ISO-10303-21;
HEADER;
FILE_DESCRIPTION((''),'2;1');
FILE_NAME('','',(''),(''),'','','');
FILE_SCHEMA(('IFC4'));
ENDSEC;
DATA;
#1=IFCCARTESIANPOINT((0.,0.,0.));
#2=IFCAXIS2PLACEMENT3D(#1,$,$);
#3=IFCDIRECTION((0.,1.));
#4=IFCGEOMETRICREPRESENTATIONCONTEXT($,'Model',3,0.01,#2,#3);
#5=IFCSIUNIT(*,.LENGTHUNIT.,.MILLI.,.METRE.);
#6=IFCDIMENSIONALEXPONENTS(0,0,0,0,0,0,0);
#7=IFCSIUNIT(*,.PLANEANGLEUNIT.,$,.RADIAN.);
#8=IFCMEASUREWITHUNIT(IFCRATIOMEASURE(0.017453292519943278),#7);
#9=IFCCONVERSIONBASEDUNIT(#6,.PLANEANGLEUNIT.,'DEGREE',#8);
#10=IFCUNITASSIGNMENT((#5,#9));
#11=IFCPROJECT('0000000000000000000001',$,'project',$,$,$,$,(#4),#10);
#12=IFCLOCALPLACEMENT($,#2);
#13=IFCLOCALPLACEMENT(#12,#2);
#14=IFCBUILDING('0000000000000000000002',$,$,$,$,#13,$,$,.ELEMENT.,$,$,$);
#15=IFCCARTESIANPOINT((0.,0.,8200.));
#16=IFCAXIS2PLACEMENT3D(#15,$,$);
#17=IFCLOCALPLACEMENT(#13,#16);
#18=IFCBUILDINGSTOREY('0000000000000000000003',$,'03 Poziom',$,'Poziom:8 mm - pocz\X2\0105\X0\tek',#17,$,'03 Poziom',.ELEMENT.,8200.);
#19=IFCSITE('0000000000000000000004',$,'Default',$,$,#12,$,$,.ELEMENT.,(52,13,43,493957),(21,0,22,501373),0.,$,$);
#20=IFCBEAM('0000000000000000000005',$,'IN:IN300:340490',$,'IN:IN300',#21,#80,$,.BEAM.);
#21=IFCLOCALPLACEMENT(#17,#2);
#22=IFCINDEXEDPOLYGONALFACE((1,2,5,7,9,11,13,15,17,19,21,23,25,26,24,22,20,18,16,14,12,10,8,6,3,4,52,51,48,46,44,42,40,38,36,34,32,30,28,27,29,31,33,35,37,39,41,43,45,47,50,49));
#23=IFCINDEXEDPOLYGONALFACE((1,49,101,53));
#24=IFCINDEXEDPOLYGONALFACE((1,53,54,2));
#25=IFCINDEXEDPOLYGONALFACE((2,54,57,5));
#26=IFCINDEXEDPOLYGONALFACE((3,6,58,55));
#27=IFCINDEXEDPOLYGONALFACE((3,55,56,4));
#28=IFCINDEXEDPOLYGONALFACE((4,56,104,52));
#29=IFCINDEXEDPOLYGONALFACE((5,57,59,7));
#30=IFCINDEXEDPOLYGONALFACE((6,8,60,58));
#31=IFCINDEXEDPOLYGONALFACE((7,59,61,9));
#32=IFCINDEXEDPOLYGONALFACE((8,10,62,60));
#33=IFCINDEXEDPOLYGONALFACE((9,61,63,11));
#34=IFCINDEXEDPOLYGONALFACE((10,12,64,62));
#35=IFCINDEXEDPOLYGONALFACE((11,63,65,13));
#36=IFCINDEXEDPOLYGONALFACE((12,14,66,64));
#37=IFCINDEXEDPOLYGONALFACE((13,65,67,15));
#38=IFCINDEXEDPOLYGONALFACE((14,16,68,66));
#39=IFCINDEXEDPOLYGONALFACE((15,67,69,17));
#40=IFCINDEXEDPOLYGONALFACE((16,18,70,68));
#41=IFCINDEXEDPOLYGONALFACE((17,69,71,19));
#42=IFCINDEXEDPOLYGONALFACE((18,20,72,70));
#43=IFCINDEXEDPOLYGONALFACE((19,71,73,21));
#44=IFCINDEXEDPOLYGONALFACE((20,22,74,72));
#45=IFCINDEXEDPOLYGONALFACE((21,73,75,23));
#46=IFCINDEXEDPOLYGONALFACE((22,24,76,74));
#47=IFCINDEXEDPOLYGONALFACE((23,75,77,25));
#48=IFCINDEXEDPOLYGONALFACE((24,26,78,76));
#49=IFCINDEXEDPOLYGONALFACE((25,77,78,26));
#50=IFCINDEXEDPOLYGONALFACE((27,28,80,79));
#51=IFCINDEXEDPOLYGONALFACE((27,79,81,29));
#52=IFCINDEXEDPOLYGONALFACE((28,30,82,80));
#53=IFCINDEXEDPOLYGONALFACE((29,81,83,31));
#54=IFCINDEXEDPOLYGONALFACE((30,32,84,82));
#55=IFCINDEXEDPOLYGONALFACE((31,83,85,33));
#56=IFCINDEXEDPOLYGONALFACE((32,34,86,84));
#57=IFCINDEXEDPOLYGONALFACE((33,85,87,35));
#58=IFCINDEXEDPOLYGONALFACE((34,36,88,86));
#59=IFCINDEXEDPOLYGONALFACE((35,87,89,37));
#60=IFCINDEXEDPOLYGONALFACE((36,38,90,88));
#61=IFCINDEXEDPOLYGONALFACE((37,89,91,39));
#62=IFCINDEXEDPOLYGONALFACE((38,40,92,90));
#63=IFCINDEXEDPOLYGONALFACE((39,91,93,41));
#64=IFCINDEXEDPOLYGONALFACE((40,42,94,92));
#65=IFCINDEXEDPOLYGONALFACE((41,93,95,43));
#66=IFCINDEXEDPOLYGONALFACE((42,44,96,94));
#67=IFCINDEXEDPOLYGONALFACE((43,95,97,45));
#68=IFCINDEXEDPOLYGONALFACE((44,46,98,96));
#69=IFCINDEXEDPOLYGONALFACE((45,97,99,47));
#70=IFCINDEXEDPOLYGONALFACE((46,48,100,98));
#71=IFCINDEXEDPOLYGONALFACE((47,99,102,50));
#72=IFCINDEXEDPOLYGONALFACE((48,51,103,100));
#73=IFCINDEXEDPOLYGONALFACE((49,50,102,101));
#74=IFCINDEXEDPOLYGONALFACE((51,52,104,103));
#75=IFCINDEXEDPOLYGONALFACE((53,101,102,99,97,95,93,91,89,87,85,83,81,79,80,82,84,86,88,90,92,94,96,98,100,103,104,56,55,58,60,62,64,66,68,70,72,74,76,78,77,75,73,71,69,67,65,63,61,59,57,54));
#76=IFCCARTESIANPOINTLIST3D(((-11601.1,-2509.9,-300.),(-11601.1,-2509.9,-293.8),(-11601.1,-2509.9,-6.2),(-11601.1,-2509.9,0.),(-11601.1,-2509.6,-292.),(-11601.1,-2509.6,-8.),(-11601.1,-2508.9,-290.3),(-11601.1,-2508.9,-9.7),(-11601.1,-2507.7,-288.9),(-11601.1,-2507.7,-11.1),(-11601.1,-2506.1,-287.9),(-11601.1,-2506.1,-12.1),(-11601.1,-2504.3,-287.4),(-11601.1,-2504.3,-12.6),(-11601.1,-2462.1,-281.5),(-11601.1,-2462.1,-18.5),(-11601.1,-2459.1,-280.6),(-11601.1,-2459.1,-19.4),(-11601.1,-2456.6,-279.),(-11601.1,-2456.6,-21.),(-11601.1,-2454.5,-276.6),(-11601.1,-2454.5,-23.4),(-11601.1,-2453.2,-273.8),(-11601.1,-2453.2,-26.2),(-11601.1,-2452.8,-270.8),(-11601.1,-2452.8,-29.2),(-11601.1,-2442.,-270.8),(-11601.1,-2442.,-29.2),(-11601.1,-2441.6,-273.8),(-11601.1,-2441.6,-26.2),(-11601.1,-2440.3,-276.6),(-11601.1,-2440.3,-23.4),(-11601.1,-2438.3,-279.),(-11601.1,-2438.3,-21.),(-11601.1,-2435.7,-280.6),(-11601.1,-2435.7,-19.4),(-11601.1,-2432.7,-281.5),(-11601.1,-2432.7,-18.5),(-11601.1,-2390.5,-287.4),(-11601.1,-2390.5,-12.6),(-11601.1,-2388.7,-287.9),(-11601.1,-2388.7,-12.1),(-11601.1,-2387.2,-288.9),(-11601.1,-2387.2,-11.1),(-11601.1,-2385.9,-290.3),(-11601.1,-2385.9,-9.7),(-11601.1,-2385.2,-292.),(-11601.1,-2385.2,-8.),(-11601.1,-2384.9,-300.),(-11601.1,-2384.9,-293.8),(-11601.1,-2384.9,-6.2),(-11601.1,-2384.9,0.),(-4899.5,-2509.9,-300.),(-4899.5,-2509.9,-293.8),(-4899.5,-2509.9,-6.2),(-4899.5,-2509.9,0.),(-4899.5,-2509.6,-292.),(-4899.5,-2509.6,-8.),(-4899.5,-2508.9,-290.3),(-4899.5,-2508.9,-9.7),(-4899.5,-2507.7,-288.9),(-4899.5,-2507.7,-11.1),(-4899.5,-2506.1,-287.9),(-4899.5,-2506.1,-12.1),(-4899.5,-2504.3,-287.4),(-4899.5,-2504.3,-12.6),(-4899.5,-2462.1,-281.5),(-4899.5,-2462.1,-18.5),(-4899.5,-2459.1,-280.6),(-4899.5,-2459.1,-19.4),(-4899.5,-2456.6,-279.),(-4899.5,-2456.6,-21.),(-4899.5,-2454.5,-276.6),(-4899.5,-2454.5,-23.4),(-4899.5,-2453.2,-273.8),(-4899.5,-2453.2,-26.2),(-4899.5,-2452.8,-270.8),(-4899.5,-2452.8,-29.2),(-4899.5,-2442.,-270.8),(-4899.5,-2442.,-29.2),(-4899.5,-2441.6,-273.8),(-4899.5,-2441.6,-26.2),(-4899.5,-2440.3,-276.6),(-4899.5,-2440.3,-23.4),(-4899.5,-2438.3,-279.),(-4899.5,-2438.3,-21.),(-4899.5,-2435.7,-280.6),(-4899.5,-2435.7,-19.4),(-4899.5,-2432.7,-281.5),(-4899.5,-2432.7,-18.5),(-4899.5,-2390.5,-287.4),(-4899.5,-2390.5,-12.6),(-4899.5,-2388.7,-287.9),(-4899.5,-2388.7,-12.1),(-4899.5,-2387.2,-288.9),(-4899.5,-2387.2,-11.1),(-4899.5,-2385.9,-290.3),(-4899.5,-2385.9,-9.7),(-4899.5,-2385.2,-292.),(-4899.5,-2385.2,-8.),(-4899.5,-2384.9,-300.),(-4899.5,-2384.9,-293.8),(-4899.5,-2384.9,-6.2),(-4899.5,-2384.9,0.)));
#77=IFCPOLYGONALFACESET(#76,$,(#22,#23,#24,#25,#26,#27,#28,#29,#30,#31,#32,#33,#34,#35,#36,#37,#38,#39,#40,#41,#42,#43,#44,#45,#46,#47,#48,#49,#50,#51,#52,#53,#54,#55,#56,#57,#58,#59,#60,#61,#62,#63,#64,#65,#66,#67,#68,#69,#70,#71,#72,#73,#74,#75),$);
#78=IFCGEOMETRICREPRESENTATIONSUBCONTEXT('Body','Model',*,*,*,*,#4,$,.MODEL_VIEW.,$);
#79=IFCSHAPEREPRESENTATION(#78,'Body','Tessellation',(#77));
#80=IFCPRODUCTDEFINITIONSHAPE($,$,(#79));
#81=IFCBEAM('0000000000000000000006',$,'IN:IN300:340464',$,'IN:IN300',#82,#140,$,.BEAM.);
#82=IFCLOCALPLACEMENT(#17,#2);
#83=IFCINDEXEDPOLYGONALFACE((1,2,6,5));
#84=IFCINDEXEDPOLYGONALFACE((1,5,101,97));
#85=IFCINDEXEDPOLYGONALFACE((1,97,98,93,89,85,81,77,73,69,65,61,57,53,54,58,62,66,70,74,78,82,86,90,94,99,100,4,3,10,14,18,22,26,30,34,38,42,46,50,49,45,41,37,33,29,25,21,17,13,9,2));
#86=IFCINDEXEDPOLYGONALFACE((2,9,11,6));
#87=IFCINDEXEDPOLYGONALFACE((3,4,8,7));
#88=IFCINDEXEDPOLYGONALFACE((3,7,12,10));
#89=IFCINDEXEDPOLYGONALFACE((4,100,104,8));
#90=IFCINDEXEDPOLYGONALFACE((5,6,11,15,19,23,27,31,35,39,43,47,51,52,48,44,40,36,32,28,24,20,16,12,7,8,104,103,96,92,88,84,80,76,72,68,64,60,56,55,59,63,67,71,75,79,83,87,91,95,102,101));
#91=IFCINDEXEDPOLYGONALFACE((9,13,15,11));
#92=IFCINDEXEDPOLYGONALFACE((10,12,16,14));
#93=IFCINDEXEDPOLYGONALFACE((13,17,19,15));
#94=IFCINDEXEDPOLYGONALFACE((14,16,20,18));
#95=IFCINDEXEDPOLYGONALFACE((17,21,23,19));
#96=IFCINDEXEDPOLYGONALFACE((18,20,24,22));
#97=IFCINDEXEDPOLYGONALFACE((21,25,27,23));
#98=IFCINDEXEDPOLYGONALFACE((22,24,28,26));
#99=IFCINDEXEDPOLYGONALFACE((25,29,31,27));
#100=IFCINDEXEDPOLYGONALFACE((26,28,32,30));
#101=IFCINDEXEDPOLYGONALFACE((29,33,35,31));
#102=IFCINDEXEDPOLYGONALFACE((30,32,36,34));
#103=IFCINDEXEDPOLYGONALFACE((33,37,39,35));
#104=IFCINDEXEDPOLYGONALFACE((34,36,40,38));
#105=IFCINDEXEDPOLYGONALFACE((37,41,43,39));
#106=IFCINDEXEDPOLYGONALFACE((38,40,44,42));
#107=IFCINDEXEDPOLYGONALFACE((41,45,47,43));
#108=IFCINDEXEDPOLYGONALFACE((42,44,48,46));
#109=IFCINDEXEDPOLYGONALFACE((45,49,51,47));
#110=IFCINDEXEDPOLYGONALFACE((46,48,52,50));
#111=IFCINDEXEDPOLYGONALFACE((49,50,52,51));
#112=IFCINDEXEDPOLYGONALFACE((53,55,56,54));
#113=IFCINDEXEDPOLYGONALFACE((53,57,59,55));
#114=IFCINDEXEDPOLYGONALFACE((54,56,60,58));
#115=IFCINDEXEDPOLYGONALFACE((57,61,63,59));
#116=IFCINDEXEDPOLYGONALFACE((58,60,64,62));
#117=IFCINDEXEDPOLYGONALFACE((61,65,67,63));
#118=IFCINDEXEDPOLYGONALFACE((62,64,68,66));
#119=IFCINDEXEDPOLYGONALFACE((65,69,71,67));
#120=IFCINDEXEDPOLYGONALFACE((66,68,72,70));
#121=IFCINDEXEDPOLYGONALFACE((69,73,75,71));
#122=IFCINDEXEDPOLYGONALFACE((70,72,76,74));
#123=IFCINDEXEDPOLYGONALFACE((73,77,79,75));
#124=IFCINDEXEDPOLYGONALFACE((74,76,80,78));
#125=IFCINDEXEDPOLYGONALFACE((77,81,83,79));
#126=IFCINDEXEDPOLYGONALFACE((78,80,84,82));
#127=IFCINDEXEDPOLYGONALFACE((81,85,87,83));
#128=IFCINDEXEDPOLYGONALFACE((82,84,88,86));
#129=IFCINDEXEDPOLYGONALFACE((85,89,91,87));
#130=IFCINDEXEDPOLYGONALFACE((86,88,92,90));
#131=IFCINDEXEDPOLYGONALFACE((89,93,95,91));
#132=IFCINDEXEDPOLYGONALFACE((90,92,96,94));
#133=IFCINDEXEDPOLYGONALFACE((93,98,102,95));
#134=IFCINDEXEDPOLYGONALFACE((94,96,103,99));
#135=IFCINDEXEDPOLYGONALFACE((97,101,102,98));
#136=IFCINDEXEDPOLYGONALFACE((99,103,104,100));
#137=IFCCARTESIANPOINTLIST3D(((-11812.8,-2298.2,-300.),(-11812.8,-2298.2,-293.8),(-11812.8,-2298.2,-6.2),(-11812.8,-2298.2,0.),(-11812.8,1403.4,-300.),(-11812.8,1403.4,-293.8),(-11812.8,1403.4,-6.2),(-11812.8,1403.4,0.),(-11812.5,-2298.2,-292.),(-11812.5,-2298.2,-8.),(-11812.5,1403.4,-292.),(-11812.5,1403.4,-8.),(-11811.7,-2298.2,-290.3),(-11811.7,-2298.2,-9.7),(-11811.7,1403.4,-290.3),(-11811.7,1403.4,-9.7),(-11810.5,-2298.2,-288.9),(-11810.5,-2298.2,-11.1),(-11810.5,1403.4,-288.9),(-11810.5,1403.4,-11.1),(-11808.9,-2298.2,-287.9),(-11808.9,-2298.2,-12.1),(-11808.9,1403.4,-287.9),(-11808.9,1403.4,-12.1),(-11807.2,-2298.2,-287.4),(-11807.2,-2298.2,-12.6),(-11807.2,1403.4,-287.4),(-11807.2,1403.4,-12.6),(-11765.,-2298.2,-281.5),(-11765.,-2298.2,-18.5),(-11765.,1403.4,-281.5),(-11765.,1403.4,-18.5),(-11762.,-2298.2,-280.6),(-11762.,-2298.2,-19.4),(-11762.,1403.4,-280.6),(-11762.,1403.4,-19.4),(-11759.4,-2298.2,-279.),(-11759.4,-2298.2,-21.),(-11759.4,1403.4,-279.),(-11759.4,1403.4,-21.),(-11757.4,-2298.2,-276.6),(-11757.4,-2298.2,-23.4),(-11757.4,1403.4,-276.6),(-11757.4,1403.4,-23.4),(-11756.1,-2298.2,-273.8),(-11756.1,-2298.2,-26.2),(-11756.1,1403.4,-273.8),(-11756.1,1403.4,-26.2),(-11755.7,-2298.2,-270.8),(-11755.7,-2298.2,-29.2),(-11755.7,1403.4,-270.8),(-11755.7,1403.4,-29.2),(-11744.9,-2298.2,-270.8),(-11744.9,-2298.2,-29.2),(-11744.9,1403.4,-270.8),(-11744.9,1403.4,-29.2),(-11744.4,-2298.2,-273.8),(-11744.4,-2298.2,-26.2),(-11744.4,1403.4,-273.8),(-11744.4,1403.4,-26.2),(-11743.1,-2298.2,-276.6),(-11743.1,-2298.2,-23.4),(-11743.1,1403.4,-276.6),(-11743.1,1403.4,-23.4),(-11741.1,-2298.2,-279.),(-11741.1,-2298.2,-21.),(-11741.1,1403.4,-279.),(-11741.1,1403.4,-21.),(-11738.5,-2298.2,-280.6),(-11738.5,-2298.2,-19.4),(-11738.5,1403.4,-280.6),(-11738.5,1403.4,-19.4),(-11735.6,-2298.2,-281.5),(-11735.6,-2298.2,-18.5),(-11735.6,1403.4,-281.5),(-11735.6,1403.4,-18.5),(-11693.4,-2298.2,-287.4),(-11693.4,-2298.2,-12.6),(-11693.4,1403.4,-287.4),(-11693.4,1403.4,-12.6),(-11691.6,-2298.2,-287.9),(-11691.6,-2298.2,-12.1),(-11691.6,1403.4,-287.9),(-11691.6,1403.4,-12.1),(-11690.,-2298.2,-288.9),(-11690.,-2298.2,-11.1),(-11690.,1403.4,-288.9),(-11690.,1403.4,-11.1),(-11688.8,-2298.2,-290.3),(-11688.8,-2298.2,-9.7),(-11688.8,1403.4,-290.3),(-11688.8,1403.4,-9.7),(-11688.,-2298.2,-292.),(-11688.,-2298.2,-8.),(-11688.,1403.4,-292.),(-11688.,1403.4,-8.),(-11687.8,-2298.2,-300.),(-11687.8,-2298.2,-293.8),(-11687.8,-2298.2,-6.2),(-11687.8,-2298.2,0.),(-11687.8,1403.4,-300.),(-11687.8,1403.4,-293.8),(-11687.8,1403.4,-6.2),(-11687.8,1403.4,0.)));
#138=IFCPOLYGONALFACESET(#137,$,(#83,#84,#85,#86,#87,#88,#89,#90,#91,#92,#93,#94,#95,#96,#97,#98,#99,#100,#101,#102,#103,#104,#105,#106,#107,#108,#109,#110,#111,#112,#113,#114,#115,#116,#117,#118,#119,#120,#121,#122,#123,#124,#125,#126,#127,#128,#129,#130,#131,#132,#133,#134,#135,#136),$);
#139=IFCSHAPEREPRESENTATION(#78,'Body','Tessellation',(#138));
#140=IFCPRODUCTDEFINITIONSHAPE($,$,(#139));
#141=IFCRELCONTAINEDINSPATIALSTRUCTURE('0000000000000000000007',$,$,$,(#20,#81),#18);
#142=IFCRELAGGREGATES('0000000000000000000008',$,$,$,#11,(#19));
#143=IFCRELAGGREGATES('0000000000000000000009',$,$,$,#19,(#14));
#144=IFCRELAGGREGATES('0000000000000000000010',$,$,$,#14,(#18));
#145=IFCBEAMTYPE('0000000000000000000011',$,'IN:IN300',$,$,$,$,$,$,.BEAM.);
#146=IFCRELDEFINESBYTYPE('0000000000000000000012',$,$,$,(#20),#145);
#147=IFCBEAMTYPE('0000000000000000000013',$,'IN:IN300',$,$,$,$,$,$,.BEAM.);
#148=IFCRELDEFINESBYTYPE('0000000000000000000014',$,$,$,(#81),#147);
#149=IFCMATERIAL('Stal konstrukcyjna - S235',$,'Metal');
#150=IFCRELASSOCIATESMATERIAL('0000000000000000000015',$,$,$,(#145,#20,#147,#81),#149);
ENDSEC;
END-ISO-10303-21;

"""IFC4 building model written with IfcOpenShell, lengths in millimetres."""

from ifc_helpers import new_model, entity, si_unit, converted_unit, direction, frame, origin, place, context, subcontext, project, spatial, line, arc, indexed_curve, outline, extrude, source, transform, mapped, material, type_object, type_shapes, element, save


model = new_model("IFC4")

# Units and contexts
model_context = context("Model", 3, precision=0.01, world=origin(), true_north=direction((0.0, 1.0)))
body_context = subcontext(model_context, "Body", "Model", "MODEL_VIEW")
ifc_project = project(units=[si_unit("LENGTHUNIT", "METRE", prefix="MILLI"), converted_unit("PLANEANGLEUNIT", "DEGREE", entity("IfcRatioMeasure", 0.017453292519943278), si_unit("PLANEANGLEUNIT", "RADIAN"), dimensions=[0, 0, 0, 0, 0, 0, 0])], contexts=[model_context])

# Site, building, storey
site_placement = place(None, origin())
site = spatial("IfcSite", under=ifc_project, at=site_placement, Name="Default", CompositionType="ELEMENT", RefLatitude=(52, 13, 43, 493957), RefLongitude=(21, 0, 22, 501373), RefElevation=0.0)
building_placement = place(site_placement, origin())
building = spatial("IfcBuilding", under=site, at=building_placement, CompositionType="ELEMENT")
storey_placement = place(building_placement, frame((0.0, 0.0, 8200.0)))
storey = spatial("IfcBuildingStorey", under=building, at=storey_placement, Name="03 Poziom", ObjectType="Poziom:8 mm - początek", LongName="03 Poziom", CompositionType="ELEMENT", Elevation=8200.0)

# Shared definitions
ifc_material_1 = material(Name="Stal konstrukcyjna - S235", Category="Metal")

# Beams
beam_type_1 = type_object("IfcBeamType", Name="IN:IN300", PredefinedType="BEAM", material=ifc_material_1)
shared_shape_1 = source(origin(), body_context, "Body", "SweptSolid", [
    extrude(outline(indexed_curve([(143.8, -62.5), (150.0, -62.5), (150.0, 62.5), (143.8, 62.5), (139.6, 60.9), (137.4, 56.9), (131.5, 14.7), (127.9, 8.1), (120.8, 5.4), (-120.8, 5.4), (-127.9, 8.1), (-131.5, 14.7), (-137.4, 56.9), (-139.6, 60.9), (-143.8, 62.5), (-150.0, 62.5), (-150.0, -62.5), (-143.8, -62.5), (-139.6, -60.9), (-137.4, -56.9), (-131.5, -14.7), (-127.9, -8.1), (-120.8, -5.4), (120.8, -5.4), (127.9, -8.1), (131.5, -14.7), (137.4, -56.9), (139.6, -60.9)], segments=[line(1, 2, 3, 4), arc(4, 5, 6), line(6, 7), arc(7, 8, 9), line(9, 10), arc(10, 11, 12), line(12, 13), arc(13, 14, 15), line(15, 16, 17, 18), arc(18, 19, 20), line(20, 21), arc(21, 22, 23), line(23, 24), arc(24, 25, 26), line(26, 27), arc(27, 28, 1)], self_intersect=False)), frame((-3350.8, 0.0, 0.0), z_axis=(1.0, 0.0, 0.0), x_axis=(0.0, 0.0, -1.0)), (0.0, 0.0, 1.0), 6701.6),
])
type_shapes(beam_type_1, [shared_shape_1])
for number, where, name in (
    (1, (-8250.3, -2447.4, -150.0), "IN:IN300:340490"),
):
    element("IfcBeam", number, at=place(storey_placement, frame(where)), inside=storey, type_object=beam_type_1, material=ifc_material_1, Name=name, ObjectType="IN:IN300", PredefinedType="BEAM", context=body_context, shape_type="MappedRepresentation", body=[
        mapped(shared_shape_1, transform((0.0, 0.0, 0.0), scale=1.0)),
    ])
beam_type_2 = type_object("IfcBeamType", Name="IN:IN300", PredefinedType="BEAM", material=ifc_material_1)
shared_shape_2 = source(origin(), body_context, "Body", "SweptSolid", [
    extrude(outline(indexed_curve([(143.8, -62.5), (150.0, -62.5), (150.0, 62.5), (143.8, 62.5), (139.6, 60.9), (137.4, 56.9), (131.5, 14.7), (127.9, 8.1), (120.8, 5.4), (-120.8, 5.4), (-127.9, 8.1), (-131.5, 14.7), (-137.4, 56.9), (-139.6, 60.9), (-143.8, 62.5), (-150.0, 62.5), (-150.0, -62.5), (-143.8, -62.5), (-139.6, -60.9), (-137.4, -56.9), (-131.5, -14.7), (-127.9, -8.1), (-120.8, -5.4), (120.8, -5.4), (127.9, -8.1), (131.5, -14.7), (137.4, -56.9), (139.6, -60.9)], segments=[line(1, 2, 3, 4), arc(4, 5, 6), line(6, 7), arc(7, 8, 9), line(9, 10), arc(10, 11, 12), line(12, 13), arc(13, 14, 15), line(15, 16, 17, 18), arc(18, 19, 20), line(20, 21), arc(21, 22, 23), line(23, 24), arc(24, 25, 26), line(26, 27), arc(27, 28, 1)], self_intersect=False)), frame((-1850.8, 0.0, 0.0), z_axis=(1.0, 0.0, 0.0), x_axis=(0.0, 0.0, -1.0)), (0.0, 0.0, 1.0), 3701.6),
])
type_shapes(beam_type_2, [shared_shape_2])
for number, where, z_axis, x_axis, name in (
    (2, (-11750.3, -447.4, -150.0), (0.0, 0.0, 1.0), (0.0, -1.0, 0.0), "IN:IN300:340464"),
):
    element("IfcBeam", number, at=place(storey_placement, frame(where, z_axis=z_axis, x_axis=x_axis)), inside=storey, type_object=beam_type_2, material=ifc_material_1, Name=name, ObjectType="IN:IN300", PredefinedType="BEAM", context=body_context, shape_type="MappedRepresentation", body=[
        mapped(shared_shape_2, transform((0.0, 0.0, 0.0), scale=1.0)),
    ])

save(model, "model.ifc")
